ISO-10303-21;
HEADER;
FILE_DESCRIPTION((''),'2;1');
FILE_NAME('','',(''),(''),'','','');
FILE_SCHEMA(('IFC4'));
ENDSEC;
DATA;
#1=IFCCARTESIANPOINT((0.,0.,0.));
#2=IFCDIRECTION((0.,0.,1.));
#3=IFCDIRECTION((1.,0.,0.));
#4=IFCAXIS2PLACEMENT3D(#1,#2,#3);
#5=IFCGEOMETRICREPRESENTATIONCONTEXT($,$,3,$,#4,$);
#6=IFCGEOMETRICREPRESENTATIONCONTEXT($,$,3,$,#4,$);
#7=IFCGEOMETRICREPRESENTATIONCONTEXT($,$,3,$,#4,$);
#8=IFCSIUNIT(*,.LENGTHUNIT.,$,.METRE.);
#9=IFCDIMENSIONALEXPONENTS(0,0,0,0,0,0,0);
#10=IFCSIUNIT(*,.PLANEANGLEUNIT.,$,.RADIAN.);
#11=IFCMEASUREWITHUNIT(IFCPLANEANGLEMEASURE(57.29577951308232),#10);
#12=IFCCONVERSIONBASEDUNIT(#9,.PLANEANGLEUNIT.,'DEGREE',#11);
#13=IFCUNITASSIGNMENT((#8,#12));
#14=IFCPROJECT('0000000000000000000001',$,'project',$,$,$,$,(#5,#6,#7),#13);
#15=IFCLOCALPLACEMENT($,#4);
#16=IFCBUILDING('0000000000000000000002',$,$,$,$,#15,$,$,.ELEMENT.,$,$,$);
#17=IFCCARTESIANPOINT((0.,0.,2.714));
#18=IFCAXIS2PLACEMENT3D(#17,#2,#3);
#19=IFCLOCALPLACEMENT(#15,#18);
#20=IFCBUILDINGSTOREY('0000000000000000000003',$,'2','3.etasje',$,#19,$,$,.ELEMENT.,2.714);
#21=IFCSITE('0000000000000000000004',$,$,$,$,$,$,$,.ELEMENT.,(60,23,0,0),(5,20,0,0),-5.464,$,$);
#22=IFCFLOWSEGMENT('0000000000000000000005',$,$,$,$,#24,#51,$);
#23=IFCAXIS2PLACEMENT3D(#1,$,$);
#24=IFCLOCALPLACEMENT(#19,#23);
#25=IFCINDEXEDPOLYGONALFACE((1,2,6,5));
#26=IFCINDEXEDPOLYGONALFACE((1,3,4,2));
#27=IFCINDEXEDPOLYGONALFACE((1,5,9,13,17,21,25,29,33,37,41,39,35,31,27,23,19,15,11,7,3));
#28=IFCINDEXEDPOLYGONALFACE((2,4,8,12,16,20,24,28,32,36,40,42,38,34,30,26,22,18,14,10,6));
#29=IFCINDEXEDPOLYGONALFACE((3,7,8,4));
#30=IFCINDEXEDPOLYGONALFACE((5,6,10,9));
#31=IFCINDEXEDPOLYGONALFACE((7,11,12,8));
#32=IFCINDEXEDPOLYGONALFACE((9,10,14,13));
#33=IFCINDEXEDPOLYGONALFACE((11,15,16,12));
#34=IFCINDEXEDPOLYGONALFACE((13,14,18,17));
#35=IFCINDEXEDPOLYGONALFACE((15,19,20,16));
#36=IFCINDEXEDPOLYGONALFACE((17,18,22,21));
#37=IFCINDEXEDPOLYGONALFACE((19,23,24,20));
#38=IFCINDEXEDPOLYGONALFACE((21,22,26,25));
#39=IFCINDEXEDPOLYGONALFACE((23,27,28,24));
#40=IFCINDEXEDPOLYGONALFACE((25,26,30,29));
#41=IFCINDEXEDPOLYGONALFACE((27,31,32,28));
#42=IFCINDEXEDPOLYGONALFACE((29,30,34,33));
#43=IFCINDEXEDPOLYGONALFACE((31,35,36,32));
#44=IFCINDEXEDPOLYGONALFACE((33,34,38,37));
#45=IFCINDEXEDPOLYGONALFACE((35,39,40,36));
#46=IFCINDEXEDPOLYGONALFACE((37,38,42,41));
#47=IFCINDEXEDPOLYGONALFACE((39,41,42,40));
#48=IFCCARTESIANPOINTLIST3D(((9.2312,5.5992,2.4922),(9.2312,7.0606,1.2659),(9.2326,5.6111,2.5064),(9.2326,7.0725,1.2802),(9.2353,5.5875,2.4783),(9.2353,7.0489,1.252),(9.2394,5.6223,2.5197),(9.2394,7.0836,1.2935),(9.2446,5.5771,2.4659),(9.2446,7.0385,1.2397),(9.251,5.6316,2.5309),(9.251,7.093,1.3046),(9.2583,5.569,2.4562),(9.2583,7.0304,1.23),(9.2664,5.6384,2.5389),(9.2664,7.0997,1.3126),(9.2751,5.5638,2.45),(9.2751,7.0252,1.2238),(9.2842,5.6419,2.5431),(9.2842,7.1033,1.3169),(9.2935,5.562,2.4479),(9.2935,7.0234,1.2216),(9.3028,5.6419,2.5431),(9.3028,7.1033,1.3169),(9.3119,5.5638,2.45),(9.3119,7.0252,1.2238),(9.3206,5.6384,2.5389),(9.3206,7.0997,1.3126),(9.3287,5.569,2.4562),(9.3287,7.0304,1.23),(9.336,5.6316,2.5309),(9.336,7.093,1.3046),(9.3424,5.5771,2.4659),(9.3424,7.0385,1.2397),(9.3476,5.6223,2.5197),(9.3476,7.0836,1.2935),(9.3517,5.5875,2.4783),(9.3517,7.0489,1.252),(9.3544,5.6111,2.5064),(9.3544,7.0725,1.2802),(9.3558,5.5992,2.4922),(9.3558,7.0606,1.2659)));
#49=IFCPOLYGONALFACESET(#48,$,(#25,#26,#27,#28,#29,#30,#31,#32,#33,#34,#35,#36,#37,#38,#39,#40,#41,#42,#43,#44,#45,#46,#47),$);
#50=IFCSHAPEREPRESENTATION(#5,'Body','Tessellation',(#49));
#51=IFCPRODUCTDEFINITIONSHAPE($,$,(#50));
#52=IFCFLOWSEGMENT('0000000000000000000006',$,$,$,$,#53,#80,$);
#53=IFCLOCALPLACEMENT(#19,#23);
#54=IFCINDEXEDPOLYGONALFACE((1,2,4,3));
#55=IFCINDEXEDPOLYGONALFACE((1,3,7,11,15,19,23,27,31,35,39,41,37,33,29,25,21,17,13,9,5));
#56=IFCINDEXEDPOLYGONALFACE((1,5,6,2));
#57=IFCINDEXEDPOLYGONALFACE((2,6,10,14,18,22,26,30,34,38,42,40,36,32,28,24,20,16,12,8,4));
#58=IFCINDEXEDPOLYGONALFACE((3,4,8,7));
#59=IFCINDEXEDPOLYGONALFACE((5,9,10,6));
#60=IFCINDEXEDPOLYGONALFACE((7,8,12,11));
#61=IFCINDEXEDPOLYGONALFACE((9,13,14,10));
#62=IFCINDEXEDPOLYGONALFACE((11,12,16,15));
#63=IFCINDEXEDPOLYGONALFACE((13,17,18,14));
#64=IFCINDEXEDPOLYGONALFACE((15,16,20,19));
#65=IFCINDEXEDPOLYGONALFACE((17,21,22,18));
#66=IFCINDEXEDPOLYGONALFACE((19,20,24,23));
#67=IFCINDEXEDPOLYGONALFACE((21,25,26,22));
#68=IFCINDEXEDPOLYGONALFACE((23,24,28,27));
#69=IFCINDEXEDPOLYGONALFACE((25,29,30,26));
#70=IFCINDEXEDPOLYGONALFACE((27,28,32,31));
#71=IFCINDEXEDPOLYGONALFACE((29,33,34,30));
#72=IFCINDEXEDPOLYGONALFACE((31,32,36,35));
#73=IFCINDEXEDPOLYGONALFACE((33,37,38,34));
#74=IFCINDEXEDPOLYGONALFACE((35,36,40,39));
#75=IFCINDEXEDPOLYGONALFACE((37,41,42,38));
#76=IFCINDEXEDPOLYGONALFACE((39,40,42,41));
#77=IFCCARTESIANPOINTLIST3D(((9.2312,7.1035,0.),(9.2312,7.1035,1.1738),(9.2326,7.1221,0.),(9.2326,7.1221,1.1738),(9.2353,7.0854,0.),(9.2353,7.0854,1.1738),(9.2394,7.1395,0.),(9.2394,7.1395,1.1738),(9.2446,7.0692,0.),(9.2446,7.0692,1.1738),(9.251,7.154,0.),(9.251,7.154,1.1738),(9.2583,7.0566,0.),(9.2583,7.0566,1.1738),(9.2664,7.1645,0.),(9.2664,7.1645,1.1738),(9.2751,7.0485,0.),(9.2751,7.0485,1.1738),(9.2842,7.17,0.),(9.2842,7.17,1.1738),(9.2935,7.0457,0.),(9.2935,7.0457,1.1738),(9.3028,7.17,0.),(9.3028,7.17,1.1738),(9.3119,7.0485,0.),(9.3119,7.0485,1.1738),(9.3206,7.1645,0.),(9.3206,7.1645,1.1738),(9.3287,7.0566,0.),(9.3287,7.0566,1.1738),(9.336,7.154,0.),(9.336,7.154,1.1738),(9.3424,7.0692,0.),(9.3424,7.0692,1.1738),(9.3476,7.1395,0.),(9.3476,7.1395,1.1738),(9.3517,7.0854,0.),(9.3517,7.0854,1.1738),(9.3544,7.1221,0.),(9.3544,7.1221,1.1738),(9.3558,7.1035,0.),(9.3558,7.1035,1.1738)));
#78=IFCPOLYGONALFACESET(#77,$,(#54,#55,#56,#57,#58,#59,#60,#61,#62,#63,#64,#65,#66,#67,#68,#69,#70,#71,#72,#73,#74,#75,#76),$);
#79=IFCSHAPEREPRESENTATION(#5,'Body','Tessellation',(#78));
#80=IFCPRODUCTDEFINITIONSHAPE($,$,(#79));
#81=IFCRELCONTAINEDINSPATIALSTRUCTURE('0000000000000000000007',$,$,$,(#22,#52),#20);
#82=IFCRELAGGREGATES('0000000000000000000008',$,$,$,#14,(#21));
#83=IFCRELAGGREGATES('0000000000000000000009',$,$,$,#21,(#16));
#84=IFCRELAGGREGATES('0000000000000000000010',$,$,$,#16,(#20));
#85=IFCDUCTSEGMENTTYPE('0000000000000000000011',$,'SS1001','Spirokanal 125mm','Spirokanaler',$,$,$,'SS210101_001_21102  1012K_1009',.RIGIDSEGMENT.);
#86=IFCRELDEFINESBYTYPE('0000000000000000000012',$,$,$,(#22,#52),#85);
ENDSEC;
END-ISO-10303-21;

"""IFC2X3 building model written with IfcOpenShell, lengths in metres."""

from ifc_helpers import new_model, entity, si_unit, converted_unit, frame, origin_with_axes, origin_2d_with_axis, place, context, project, spatial, circle, extrude, type_object, element, save


model = new_model("IFC2X3")

# Units and contexts
context_of_model_1 = context(None, 3, world=origin_with_axes())
context_of_model_2 = context(None, 3, world=origin_with_axes())
context_of_model_3 = context(None, 3, world=origin_with_axes())
ifc_project = project(units=[si_unit("LENGTHUNIT", "METRE"), converted_unit("PLANEANGLEUNIT", "DEGREE", entity("IfcPlaneAngleMeasure", 57.29577951308232), si_unit("PLANEANGLEUNIT", "RADIAN"), dimensions=[0, 0, 0, 0, 0, 0, 0])], contexts=[context_of_model_1, context_of_model_2, context_of_model_3])

# Site, building, storey
site = spatial("IfcSite", under=ifc_project, CompositionType="ELEMENT", RefLatitude=(60, 23, 0, 0), RefLongitude=(5, 20, 0, 0), RefElevation=-5.464)
building_placement = place(None, origin_with_axes())
building = spatial("IfcBuilding", under=site, at=building_placement, CompositionType="ELEMENT")
storey_placement = place(building_placement, frame((0.0, 0.0, 2.714), z_axis=(0.0, 0.0, 1.0), x_axis=(1.0, 0.0, 0.0)))
storey = spatial("IfcBuildingStorey", under=building, at=storey_placement, Name="2", Description="3.etasje", CompositionType="ELEMENT", Elevation=2.714)

# Flow segments
duct_segment_type_1 = type_object("IfcDuctSegmentType", Name="SS1001", Description="Spirokanal 125mm", ApplicableOccurrence="Spirokanaler", ElementType="SS210101_001_21102  1012K_1009", PredefinedType="RIGIDSEGMENT")
flow_segment_1_placement = place(storey_placement, frame((9.2935, 5.6022, 2.4958), z_axis=(0.0, 0.766044, -0.642788), x_axis=(0.0, -0.642788, -0.766044)))
element("IfcFlowSegment", 1, at=flow_segment_1_placement, inside=storey, type_object=duct_segment_type_1, context=context_of_model_1, shape_type="SweptSolid", body=[
    extrude(circle(Radius=0.0625, at=origin_2d_with_axis()), origin_with_axes(), (0.0, 0.0, 1.0), 1.9077),
])
flow_segment_2_placement = place(storey_placement, frame((9.2935, 7.1082, 1.1738), z_axis=(0.0, 0.0, -1.0), x_axis=(0.0, -1.0, 0.0)))
element("IfcFlowSegment", 2, at=flow_segment_2_placement, inside=storey, type_object=duct_segment_type_1, context=context_of_model_1, shape_type="SweptSolid", body=[
    extrude(circle(Radius=0.0625, at=origin_2d_with_axis()), origin_with_axes(), (0.0, 0.0, 1.0), 1.1738),
])

save(model, "model.ifc")
